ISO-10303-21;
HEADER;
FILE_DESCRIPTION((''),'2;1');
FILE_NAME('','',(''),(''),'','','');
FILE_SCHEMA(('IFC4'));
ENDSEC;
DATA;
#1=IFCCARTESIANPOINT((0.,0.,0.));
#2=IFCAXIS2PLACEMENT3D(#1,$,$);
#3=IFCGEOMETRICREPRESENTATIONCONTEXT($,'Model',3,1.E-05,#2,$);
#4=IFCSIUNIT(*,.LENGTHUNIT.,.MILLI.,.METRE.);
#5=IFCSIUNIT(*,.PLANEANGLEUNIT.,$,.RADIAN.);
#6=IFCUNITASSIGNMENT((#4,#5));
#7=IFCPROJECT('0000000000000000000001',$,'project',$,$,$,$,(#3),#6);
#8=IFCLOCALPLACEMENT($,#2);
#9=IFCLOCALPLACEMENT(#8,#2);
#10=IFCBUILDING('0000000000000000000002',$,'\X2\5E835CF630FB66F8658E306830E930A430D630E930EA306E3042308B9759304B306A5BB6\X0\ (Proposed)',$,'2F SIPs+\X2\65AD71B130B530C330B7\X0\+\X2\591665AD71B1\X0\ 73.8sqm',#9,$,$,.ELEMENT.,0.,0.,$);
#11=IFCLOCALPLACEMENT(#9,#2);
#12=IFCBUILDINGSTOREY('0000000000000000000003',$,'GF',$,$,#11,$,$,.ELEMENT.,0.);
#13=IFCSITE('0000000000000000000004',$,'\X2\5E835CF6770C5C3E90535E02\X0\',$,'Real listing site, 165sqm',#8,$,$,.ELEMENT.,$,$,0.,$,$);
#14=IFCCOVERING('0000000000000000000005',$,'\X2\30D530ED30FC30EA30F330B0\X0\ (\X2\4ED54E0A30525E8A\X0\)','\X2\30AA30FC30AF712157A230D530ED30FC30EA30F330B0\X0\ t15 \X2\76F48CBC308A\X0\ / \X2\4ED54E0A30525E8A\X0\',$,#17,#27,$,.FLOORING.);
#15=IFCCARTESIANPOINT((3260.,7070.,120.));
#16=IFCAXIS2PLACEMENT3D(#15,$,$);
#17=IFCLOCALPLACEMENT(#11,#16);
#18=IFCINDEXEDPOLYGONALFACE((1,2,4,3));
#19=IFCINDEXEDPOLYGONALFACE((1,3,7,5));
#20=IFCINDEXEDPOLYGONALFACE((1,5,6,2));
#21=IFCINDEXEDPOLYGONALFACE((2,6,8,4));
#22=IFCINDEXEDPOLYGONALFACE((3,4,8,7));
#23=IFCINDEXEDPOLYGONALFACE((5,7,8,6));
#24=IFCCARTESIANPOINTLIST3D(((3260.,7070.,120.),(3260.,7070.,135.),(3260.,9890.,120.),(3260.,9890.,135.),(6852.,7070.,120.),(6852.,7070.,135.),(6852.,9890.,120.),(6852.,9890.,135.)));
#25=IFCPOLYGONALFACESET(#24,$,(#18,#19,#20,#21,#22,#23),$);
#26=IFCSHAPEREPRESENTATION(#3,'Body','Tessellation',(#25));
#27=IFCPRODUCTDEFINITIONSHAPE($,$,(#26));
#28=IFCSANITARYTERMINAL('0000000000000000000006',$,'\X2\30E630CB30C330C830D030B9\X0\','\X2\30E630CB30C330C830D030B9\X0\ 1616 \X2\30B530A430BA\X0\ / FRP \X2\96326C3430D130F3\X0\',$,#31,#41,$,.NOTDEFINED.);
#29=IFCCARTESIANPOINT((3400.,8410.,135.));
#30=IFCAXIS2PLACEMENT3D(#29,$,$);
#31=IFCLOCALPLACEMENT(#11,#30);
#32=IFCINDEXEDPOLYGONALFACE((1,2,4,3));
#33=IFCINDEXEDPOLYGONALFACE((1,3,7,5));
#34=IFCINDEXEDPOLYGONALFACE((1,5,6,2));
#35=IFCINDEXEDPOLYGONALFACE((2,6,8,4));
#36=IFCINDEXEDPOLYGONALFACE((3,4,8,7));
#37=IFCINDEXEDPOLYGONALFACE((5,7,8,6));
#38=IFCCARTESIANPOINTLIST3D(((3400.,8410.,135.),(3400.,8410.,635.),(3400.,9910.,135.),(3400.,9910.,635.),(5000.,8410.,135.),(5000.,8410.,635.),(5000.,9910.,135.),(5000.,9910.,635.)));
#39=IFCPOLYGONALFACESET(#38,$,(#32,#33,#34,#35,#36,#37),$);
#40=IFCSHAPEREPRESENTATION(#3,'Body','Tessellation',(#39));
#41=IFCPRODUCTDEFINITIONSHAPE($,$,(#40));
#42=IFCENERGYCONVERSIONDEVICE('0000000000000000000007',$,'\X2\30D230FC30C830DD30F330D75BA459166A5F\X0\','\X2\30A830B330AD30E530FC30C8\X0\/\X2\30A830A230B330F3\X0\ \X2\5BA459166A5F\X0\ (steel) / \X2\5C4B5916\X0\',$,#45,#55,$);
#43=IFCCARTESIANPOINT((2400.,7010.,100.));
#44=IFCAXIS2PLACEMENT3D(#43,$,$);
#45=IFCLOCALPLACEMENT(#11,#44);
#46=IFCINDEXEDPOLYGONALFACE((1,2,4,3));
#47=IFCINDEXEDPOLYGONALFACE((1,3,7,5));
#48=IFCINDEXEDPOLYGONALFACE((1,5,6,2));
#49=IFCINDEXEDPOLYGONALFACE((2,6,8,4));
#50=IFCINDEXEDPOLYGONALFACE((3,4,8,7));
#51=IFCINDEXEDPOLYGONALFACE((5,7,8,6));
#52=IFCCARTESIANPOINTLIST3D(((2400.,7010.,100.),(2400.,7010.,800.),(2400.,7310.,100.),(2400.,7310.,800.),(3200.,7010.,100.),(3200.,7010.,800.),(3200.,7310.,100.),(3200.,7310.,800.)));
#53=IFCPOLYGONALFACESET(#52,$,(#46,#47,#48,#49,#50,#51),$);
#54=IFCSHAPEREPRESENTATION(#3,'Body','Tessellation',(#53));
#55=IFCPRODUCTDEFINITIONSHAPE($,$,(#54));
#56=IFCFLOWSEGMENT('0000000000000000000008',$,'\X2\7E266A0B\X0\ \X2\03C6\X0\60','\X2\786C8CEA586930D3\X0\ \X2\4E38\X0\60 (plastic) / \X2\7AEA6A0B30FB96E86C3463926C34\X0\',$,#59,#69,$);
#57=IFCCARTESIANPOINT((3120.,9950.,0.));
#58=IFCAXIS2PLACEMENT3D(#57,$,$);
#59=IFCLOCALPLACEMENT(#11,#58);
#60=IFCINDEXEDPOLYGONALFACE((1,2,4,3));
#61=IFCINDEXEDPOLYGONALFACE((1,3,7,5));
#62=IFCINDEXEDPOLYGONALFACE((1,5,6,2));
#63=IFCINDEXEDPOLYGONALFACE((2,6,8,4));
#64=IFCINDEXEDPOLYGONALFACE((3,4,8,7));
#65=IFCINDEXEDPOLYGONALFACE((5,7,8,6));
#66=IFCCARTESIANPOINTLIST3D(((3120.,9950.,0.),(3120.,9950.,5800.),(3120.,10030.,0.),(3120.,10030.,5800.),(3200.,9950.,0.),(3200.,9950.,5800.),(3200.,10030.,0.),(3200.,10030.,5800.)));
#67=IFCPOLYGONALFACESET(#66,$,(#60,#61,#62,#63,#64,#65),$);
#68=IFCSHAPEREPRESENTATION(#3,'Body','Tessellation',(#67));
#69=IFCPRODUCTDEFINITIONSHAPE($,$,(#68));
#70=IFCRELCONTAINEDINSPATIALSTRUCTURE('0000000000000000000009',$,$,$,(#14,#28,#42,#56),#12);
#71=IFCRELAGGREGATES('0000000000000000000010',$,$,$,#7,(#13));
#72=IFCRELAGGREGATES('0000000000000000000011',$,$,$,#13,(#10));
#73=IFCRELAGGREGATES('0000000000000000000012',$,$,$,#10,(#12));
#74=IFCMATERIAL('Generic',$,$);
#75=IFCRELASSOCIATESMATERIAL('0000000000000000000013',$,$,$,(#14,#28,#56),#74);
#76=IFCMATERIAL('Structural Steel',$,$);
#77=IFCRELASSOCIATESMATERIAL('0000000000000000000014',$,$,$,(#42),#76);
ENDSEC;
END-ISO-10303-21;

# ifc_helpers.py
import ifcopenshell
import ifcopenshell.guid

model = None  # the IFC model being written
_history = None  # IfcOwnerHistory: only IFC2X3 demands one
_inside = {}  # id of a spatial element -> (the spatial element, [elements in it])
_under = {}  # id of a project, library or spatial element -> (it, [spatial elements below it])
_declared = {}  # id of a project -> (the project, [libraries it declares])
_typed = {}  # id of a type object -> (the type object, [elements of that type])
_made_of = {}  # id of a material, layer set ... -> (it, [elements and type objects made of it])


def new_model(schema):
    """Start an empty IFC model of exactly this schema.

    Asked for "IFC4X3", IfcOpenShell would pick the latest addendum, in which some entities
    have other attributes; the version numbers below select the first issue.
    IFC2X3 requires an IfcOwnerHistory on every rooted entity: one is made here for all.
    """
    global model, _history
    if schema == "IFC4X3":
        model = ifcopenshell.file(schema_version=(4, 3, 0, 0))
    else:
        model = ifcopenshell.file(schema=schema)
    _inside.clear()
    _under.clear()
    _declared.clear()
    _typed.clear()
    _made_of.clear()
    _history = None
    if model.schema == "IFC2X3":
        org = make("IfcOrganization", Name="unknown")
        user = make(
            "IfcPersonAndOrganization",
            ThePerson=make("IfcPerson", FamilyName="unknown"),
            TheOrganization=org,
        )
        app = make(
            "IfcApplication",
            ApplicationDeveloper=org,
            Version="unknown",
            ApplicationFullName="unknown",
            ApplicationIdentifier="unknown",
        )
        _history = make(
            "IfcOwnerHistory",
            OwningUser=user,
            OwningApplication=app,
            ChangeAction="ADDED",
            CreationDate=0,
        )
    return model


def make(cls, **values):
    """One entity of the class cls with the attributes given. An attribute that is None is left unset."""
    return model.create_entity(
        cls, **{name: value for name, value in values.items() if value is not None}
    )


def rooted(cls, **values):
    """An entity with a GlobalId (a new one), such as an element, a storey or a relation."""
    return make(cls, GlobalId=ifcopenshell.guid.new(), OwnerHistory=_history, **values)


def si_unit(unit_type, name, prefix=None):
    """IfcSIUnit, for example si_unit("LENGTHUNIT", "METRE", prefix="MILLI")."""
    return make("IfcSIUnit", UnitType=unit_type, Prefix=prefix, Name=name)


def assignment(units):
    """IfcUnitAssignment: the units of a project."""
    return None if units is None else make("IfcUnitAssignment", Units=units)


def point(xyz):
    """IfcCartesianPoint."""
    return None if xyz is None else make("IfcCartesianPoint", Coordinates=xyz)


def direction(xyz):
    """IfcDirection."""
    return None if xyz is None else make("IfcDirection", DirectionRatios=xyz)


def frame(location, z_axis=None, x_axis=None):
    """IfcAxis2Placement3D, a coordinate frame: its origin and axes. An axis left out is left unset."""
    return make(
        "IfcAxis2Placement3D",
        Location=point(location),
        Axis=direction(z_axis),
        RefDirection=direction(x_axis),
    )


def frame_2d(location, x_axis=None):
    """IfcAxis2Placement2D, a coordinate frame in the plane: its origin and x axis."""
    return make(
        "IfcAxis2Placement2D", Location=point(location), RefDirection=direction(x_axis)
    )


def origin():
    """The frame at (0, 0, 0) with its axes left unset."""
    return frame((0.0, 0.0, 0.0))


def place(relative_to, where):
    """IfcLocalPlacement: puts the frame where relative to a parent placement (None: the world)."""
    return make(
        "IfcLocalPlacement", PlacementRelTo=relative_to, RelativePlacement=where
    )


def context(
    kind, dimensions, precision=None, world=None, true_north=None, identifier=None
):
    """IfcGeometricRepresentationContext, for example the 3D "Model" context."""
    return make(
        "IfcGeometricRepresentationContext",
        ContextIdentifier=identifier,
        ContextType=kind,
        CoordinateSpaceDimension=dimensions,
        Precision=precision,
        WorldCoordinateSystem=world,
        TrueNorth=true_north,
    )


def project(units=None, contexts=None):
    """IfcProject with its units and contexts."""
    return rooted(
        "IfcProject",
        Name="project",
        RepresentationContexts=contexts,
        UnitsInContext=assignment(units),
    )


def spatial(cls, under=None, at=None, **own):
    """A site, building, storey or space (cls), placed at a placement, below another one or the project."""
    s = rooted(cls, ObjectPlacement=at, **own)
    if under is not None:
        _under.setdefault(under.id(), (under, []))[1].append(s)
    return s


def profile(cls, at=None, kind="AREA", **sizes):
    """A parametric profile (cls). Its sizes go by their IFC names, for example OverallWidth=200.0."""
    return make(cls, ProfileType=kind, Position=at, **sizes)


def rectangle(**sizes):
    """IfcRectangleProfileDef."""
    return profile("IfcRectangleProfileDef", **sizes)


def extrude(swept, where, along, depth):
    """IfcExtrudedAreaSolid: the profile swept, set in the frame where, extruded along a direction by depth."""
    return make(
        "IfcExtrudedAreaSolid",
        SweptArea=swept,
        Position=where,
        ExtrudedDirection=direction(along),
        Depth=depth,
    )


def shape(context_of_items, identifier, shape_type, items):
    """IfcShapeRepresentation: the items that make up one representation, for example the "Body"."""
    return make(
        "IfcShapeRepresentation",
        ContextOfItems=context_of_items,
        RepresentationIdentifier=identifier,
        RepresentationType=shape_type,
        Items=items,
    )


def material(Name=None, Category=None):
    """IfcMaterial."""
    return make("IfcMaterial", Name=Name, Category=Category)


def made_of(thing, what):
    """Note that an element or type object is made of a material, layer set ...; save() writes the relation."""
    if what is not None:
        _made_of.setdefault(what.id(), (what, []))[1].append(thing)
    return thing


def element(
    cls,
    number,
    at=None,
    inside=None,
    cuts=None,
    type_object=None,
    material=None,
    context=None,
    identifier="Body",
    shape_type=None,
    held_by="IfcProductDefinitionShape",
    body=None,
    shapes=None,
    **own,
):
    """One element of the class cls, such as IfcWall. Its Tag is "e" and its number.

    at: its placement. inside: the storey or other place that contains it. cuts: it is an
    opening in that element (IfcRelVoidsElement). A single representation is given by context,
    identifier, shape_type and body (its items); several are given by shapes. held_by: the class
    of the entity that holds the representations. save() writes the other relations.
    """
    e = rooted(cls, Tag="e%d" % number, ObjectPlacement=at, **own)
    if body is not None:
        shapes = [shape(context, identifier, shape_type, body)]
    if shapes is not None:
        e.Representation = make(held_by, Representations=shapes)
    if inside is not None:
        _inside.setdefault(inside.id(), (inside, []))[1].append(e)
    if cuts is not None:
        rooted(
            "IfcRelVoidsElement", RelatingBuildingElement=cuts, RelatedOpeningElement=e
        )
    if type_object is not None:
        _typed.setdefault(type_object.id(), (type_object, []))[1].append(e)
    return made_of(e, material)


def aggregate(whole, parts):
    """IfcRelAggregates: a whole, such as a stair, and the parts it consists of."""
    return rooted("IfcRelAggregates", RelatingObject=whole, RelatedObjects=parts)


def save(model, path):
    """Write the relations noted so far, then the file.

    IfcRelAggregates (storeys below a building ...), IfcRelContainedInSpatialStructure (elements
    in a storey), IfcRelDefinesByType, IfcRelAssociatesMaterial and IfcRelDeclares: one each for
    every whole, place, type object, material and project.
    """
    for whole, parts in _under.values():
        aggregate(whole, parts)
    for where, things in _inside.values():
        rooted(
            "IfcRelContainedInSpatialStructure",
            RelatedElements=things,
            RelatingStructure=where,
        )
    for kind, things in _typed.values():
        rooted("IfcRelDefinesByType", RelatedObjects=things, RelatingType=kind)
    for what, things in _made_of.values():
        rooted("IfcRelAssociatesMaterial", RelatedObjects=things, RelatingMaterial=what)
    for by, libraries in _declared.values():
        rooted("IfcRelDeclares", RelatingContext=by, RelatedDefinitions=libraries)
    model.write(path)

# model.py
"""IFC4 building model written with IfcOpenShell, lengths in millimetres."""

from ifc_helpers import new_model, si_unit, frame, frame_2d, origin, place, context, project, spatial, rectangle, extrude, material, element, save


model = new_model("IFC4")

# Units and contexts
model_context = context("Model", 3, precision=1e-05, world=origin())
ifc_project = project(units=[si_unit("LENGTHUNIT", "METRE", prefix="MILLI"), si_unit("PLANEANGLEUNIT", "RADIAN")], contexts=[model_context])

# Site, building, storey
site_placement = place(None, origin())
site = spatial("IfcSite", under=ifc_project, at=site_placement, Name="広島県尾道市", ObjectType="Real listing site, 165sqm", CompositionType="ELEMENT", RefElevation=0.0)
building_placement = place(site_placement, origin())
building = spatial("IfcBuilding", under=site, at=building_placement, Name="広島・書斎とライブラリのある静かな家 (Proposed)", ObjectType="2F SIPs+断熱サッシ+外断熱 73.8sqm", CompositionType="ELEMENT", ElevationOfRefHeight=0.0, ElevationOfTerrain=0.0)
storey_placement = place(building_placement, origin())
storey = spatial("IfcBuildingStorey", under=building, at=storey_placement, Name="GF", CompositionType="ELEMENT", Elevation=0.0)

# Covering
ifc_material_1 = material(Name="Generic")
covering_placement = place(storey_placement, frame((3260.0, 7070.0, 120.0)))
element("IfcCovering", 1, at=covering_placement, inside=storey, material=ifc_material_1, Name="フローリング (仕上げ床)", Description="オーク無垢フローリング t15 直貼り / 仕上げ床", PredefinedType="FLOORING", context=model_context, shape_type="SweptSolid", body=[
    extrude(rectangle(XDim=3592.0, YDim=2820.0, at=frame_2d((1796.0, 1410.0))), frame((3260.0, 7070.0, 120.0)), (0.0, 0.0, 1.0), 15.0),
])

# Sanitary terminal
sanitary_terminal_placement = place(storey_placement, frame((3400.0, 8410.0, 135.0)))
element("IfcSanitaryTerminal", 2, at=sanitary_terminal_placement, inside=storey, material=ifc_material_1, Name="ユニットバス", Description="ユニットバス 1616 サイズ / FRP 防水パン", PredefinedType="NOTDEFINED", context=model_context, shape_type="SweptSolid", body=[
    extrude(rectangle(XDim=1600.0, YDim=1500.0, at=frame_2d((800.0, 750.0))), frame((3400.0, 8410.0, 135.0)), (0.0, 0.0, 1.0), 500.0),
])

# Energy conversion device
ifc_material_2 = material(Name="Structural Steel")
energy_conversion_device_placement = place(storey_placement, frame((2400.0, 7010.0, 100.0)))
element("IfcEnergyConversionDevice", 3, at=energy_conversion_device_placement, inside=storey, material=ifc_material_2, Name="ヒートポンプ室外機", Description="エコキュート/エアコン 室外機 (steel) / 屋外", context=model_context, shape_type="SweptSolid", body=[
    extrude(rectangle(XDim=800.0, YDim=300.0, at=frame_2d((400.0, 150.0))), frame((2400.0, 7010.0, 100.0)), (0.0, 0.0, 1.0), 700.0),
])

# Flow segment
flow_segment_placement = place(storey_placement, frame((3120.0, 9950.0, 0.0)))
element("IfcFlowSegment", 4, at=flow_segment_placement, inside=storey, material=ifc_material_1, Name="縦樋 φ60", Description="硬質塩ビ 丸60 (plastic) / 竪樋・雨水排水", context=model_context, shape_type="SweptSolid", body=[
    extrude(rectangle(XDim=80.0, YDim=80.0, at=frame_2d((40.0, 40.0))), frame((3120.0, 9950.0, 0.0)), (0.0, 0.0, 1.0), 5800.0),
])

save(model, "model.ifc")
